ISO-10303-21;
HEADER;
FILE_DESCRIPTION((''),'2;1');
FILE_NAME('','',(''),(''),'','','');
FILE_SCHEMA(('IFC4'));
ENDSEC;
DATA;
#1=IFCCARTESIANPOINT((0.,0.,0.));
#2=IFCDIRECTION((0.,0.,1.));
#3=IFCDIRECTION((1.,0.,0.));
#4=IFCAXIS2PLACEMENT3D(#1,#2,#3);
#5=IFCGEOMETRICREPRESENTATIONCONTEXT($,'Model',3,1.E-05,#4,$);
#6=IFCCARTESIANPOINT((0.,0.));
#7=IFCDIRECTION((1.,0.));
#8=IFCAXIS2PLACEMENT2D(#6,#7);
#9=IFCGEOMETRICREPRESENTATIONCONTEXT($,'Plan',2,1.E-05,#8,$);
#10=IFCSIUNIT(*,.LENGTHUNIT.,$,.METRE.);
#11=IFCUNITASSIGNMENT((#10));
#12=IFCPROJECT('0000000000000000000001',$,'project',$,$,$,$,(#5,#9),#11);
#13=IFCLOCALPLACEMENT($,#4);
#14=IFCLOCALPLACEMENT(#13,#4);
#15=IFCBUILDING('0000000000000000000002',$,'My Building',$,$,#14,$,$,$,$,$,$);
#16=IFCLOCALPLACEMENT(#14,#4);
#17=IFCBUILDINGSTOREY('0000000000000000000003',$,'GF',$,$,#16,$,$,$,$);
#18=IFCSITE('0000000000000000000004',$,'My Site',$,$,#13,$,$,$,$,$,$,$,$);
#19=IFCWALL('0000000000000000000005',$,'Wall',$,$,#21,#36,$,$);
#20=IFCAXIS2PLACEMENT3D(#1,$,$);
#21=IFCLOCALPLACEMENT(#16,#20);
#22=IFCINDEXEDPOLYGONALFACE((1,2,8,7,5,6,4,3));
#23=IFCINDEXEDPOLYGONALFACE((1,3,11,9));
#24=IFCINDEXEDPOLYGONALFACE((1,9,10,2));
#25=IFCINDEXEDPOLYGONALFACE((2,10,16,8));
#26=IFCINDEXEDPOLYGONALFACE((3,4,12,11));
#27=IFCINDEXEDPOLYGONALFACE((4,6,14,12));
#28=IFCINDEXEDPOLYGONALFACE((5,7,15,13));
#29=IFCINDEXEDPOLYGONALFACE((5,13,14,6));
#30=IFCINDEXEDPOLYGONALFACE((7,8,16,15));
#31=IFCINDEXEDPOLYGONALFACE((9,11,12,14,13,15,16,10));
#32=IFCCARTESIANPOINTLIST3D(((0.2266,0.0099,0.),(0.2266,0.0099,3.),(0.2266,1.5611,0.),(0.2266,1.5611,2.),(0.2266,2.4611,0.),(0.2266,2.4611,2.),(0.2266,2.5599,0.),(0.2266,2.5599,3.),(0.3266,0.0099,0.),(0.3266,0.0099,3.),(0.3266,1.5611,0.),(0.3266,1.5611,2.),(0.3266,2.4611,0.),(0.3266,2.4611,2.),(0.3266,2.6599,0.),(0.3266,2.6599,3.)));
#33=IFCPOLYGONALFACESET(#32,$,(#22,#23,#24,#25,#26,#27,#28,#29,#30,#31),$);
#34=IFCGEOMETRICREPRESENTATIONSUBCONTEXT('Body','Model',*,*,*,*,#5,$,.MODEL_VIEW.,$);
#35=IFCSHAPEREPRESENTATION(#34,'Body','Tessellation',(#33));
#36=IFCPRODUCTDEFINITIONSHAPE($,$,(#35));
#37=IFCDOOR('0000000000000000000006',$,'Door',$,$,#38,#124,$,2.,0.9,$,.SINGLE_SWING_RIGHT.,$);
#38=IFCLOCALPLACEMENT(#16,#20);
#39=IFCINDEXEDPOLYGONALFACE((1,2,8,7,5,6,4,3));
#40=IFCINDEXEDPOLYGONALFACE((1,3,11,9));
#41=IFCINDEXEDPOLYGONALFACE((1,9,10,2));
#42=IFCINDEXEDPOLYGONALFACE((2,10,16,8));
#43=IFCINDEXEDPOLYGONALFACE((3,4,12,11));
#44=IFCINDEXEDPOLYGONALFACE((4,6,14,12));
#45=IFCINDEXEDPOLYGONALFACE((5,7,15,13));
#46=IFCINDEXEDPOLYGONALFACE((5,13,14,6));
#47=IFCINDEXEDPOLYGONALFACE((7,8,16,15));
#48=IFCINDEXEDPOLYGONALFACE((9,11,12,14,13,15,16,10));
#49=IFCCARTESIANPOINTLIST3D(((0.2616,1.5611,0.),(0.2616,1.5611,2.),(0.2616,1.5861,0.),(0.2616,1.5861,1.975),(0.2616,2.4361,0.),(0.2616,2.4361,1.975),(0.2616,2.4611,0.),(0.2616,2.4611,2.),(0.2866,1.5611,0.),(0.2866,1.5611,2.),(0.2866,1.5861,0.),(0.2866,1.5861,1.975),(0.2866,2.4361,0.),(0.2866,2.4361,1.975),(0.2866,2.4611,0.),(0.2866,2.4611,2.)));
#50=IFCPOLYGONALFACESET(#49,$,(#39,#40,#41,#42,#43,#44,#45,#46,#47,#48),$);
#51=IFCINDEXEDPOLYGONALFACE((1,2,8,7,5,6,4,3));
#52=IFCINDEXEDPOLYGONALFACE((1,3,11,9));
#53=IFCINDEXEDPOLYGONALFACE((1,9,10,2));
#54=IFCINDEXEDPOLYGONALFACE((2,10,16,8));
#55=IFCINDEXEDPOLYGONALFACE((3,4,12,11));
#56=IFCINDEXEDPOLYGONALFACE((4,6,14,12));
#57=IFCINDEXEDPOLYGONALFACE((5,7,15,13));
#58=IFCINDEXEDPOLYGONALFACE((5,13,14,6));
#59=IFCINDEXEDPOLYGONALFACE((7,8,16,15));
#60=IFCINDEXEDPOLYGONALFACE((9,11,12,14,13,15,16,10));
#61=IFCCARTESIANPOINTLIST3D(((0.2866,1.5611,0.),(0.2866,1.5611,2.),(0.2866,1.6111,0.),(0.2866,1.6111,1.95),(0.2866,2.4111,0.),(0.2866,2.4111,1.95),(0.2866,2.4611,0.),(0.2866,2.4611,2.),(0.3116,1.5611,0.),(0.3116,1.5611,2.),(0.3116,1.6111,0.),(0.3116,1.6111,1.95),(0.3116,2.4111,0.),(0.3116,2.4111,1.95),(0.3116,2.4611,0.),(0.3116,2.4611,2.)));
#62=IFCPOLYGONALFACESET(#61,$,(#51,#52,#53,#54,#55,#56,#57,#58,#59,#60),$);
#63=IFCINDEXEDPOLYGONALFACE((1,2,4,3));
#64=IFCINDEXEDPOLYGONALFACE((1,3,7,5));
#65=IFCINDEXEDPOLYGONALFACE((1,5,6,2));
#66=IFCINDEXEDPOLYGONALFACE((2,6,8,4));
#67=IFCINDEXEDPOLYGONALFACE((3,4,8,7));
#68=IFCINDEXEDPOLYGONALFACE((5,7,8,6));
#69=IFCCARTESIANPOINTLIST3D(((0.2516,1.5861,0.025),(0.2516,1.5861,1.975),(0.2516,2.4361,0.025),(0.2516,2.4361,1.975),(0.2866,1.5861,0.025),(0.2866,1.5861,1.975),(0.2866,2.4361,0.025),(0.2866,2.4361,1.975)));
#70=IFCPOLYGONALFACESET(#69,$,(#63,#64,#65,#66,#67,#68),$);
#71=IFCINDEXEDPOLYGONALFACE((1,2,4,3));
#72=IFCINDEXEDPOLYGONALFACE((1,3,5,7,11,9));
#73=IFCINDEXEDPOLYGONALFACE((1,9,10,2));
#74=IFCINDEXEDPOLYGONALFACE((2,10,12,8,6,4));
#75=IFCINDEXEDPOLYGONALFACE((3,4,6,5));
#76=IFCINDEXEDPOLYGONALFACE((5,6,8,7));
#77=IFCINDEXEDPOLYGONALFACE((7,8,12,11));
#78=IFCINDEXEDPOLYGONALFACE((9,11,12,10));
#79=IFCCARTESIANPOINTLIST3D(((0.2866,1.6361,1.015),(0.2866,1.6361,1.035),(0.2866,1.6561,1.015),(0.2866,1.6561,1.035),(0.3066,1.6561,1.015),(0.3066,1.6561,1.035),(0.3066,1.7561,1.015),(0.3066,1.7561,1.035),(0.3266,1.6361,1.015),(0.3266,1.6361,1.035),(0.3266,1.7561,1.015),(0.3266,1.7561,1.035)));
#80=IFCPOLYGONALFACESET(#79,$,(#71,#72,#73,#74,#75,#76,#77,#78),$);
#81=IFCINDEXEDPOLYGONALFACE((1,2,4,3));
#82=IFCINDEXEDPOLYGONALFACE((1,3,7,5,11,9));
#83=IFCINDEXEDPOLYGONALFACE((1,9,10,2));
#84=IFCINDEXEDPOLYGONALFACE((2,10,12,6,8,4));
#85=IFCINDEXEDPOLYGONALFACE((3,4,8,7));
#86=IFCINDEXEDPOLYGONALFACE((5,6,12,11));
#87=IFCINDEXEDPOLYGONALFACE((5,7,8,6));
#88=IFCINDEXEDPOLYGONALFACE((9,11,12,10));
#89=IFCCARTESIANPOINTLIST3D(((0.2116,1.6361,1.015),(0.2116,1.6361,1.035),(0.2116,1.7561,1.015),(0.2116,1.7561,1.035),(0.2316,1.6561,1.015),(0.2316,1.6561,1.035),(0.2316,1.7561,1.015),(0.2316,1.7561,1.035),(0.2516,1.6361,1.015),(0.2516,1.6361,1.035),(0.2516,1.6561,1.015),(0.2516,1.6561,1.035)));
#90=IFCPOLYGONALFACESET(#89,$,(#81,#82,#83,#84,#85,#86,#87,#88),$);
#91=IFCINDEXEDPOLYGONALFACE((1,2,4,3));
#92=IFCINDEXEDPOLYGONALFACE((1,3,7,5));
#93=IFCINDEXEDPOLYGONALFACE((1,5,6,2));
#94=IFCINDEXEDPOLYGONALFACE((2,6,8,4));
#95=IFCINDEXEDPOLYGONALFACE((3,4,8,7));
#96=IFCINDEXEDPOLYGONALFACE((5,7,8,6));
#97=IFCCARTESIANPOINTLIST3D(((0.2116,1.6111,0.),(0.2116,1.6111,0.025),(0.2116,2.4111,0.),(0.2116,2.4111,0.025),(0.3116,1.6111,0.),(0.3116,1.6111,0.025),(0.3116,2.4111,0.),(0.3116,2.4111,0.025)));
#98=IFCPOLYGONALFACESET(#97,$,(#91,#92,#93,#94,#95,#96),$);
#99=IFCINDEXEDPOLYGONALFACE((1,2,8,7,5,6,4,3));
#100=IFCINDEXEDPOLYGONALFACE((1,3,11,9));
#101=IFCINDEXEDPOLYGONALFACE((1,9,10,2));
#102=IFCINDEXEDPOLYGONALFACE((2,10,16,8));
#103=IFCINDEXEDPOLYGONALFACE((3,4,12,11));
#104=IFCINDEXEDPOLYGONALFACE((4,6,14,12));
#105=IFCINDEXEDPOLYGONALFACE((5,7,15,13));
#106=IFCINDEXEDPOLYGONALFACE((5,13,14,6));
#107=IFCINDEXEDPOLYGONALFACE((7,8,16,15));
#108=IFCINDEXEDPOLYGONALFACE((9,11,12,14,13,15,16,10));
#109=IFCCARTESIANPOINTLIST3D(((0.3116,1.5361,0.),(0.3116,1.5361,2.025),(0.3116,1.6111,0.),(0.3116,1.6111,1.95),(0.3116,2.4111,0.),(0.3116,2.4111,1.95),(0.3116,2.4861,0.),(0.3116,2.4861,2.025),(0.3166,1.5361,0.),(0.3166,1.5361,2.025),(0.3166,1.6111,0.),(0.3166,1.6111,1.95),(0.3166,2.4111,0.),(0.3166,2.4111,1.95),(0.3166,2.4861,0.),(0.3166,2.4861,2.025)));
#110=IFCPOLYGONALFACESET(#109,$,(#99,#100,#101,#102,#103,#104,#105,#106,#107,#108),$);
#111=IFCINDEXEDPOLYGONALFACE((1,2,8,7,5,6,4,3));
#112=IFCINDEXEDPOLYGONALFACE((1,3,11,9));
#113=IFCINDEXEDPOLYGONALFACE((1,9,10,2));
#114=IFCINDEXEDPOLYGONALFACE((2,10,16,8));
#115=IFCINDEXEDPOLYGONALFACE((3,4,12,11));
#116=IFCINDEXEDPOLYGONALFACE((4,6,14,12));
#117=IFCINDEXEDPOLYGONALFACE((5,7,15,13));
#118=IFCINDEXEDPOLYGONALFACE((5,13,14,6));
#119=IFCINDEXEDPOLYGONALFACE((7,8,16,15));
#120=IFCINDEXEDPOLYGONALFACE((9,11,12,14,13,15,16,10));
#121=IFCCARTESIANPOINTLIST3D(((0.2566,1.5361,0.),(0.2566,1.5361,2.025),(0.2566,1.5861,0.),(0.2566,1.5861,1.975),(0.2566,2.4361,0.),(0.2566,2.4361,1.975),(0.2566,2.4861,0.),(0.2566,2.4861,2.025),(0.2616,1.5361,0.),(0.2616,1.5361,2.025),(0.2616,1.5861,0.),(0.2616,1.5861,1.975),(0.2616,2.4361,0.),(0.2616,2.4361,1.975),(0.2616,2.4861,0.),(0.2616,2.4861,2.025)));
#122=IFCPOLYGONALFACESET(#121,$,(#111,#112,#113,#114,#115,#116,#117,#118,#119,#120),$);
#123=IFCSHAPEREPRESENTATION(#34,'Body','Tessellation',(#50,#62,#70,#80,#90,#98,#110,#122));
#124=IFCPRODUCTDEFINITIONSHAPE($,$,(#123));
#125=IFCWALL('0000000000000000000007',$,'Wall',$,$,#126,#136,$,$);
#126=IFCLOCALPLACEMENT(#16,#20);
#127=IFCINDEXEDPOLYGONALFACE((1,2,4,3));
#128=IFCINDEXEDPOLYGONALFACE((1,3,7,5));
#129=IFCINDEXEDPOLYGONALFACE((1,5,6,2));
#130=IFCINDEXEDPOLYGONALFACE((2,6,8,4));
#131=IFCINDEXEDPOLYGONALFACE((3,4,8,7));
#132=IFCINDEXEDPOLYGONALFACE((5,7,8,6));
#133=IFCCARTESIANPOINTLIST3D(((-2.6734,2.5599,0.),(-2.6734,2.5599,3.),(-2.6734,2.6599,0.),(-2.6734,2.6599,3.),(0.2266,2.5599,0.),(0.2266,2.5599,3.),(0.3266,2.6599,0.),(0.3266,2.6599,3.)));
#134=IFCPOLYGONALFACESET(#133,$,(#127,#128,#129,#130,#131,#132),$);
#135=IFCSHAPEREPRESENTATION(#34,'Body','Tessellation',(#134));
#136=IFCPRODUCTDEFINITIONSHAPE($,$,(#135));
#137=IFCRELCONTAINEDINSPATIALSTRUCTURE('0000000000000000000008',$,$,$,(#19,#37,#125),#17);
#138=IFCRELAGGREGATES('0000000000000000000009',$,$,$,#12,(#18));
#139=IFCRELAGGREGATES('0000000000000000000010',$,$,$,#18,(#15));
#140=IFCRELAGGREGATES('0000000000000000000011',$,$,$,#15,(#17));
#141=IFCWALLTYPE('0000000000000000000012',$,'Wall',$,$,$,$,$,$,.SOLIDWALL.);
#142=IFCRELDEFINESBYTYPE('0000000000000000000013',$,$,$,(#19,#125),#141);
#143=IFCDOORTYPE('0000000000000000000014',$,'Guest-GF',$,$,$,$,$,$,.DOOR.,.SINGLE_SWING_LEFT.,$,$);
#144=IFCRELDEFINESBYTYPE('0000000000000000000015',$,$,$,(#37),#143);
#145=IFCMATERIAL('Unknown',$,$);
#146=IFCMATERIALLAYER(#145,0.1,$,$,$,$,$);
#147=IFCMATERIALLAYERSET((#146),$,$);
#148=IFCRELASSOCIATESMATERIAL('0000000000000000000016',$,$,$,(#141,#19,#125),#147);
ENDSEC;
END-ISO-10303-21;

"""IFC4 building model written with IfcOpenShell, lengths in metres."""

from ifc_helpers import new_model, entity, si_unit, frame, origin_with_axes, origin_2d_with_axis, place, context, subcontext, project, spatial, line, indexed_curve, outline, extrude, shape, source, transform, mapped, material, layer, layer_set, layer_usage, type_object, type_shapes, element, fill, save


model = new_model("IFC4")

# Units and contexts
model_context = context("Model", 3, precision=1e-05, world=origin_with_axes())
plan_context = context("Plan", 2, precision=1e-05, world=origin_2d_with_axis())
body_context_1 = subcontext(model_context, "Body", "Model", "MODEL_VIEW")
body_context_2 = subcontext(plan_context, "Body", "Plan", "PLAN_VIEW")
ifc_project = project(units=[si_unit("LENGTHUNIT", "METRE")], contexts=[model_context, plan_context])

# Site, building, storey
site_placement = place(None, origin_with_axes())
site = spatial("IfcSite", under=ifc_project, at=site_placement, Name="My Site")
building_placement = place(site_placement, origin_with_axes())
building = spatial("IfcBuilding", under=site, at=building_placement, Name="My Building")
storey_placement = place(building_placement, origin_with_axes())
storey = spatial("IfcBuildingStorey", under=building, at=storey_placement, Name="GF")

# Shared definitions
ifc_material = material(Name="Unknown")

# Shared definitions
ifc_layer_1 = layer(ifc_material, 0.1)
ifc_layer_set_1 = layer_set([ifc_layer_1])
wall_type = type_object("IfcWallType", Name="Wall", PredefinedType="SOLIDWALL", material=ifc_layer_set_1)

# Wall, opening, door
ifc_layer_usage_1 = layer_usage(ifc_layer_set_1, "AXIS2", "POSITIVE", 0.0)
wall_1_placement = place(storey_placement, frame((0.3266, 0.0099, 0.0), z_axis=(0.0, 0.0, 1.0), x_axis=(0.0, 1.0, 0.0)))
wall_1 = element("IfcWall", 1, at=wall_1_placement, inside=storey, type_object=wall_type, material=ifc_layer_usage_1, Name="Wall", context=body_context_1, shape_type="SweptSolid", body=[
    extrude(outline(indexed_curve([(0.0, 0.0), (0.0, 0.1), (2.55, 0.1), (2.65, 0.0)], segments=[line(1, 2, 3, 4, 1)])), origin_with_axes(), (0.0, 0.0, 1.0), 3.0),
])
shared_shape_1 = source(origin_with_axes(), body_context_1, "Body", "SweptSolid", [
    extrude(outline(indexed_curve([(0.0, 0.0), (0.9, 0.0), (0.9, 2.0), (0.0, 2.0)], segments=[line(1, 2, 3, 4, 1)])), frame((0.0, -0.6, 0.0), z_axis=(0.0, -1.0, 0.0), x_axis=(1.0, 0.0, 0.0)), (0.0, 0.0, -1.0), 1.2),
])
opening_1_placement = place(wall_1_placement, frame((1.5512, 0.015, 0.0), z_axis=(0.0, 0.0, 1.0), x_axis=(1.0, 0.0, 0.0)))
opening_1 = element("IfcOpeningElement", 2, at=opening_1_placement, cuts=wall_1, PredefinedType="OPENING", context=body_context_1, shape_type="MappedRepresentation", body=[
    mapped(shared_shape_1, transform((0.0, 0.0, 0.0), x_axis=(1.0, 0.0, 0.0), y_axis=(0.0, 1.0, 0.0), z_axis=(0.0, 0.0, 1.0), scale=1.0)),
])
door_type_1 = type_object("IfcDoorType", Name="Guest-GF", OperationType="SINGLE_SWING_LEFT", PredefinedType="DOOR")
shared_shape_2 = source(origin_with_axes(), body_context_1, "Body", "SweptSolid", [
    extrude(outline(indexed_curve([(0.0, 0.0), (0.0, 2.0), (0.9, 2.0), (0.9, 0.0), (0.875, 0.0), (0.875, 1.975), (0.025, 1.975), (0.025, 0.0)], segments=[line(1, 2, 3, 4, 5, 6, 7, 8, 1)])), frame((0.0, 0.025, 0.0), z_axis=(0.0, -1.0, 0.0), x_axis=(1.0, 0.0, 0.0)), (0.0, 0.0, -1.0), 0.025),
    extrude(outline(indexed_curve([(0.0, 0.0), (0.0, 2.0), (0.9, 2.0), (0.9, 0.0), (0.85, 0.0), (0.85, 1.95), (0.05, 1.95), (0.05, 0.0)], segments=[line(1, 2, 3, 4, 5, 6, 7, 8, 1)])), frame((0.0, 0.0, 0.0), z_axis=(0.0, -1.0, 0.0), x_axis=(1.0, 0.0, 0.0)), (0.0, 0.0, -1.0), 0.025),
    extrude(outline(indexed_curve([(0.0, 0.0), (0.85, 0.0), (0.85, 0.035), (0.0, 0.035)], segments=[line(1, 2, 3, 4, 1)])), frame((0.025, 0.025, 0.025), z_axis=(0.0, 0.0, 1.0), x_axis=(1.0, 0.0, 0.0)), (0.0, 0.0, 1.0), 1.95),
    extrude(outline(indexed_curve([(0.0, 0.0), (0.0, -0.04), (0.12, -0.04), (0.12, -0.02), (0.02, -0.02), (0.02, 0.0)], segments=[line(1, 2, 3, 4, 5, 6, 1)])), frame((0.075, 0.025, 1.015), z_axis=(0.0, 0.0, 1.0), x_axis=(1.0, 0.0, 0.0)), (0.0, 0.0, 1.0), 0.02),
    extrude(outline(indexed_curve([(0.0, 0.0), (0.0, 0.04), (0.12, 0.04), (0.12, 0.02), (0.02, 0.02), (0.02, 0.0)], segments=[line(1, 2, 3, 4, 5, 6, 1)])), frame((0.075, 0.06, 1.015), z_axis=(0.0, 0.0, 1.0), x_axis=(1.0, 0.0, 0.0)), (0.0, 0.0, 1.0), 0.02),
    extrude(outline(indexed_curve([(0.0, 0.0), (0.8, 0.0), (0.8, 0.1), (0.0, 0.1)], segments=[line(1, 2, 3, 4, 1)])), frame((0.05, 0.0, 0.0), z_axis=(0.0, 0.0, 1.0), x_axis=(1.0, 0.0, 0.0)), (0.0, 0.0, 1.0), 0.025),
    extrude(outline(indexed_curve([(0.0, 0.0), (0.0, 2.025), (0.95, 2.025), (0.95, 0.0), (0.875, 0.0), (0.875, 1.95), (0.075, 1.95), (0.075, 0.0)], segments=[line(1, 2, 3, 4, 5, 6, 7, 8, 1)])), frame((-0.025, -0.005, 0.0), z_axis=(0.0, -1.0, 0.0), x_axis=(1.0, 0.0, 0.0)), (0.0, 0.0, -1.0), 0.005),
    extrude(outline(indexed_curve([(0.0, 0.0), (0.0, 2.025), (0.95, 2.025), (0.95, 0.0), (0.9, 0.0), (0.9, 1.975), (0.05, 1.975), (0.05, 0.0)], segments=[line(1, 2, 3, 4, 5, 6, 7, 8, 1)])), frame((-0.025, 0.05, 0.0), z_axis=(0.0, -1.0, 0.0), x_axis=(1.0, 0.0, 0.0)), (0.0, 0.0, -1.0), 0.005),
])
shared_shape_3 = source(origin_with_axes(), body_context_2, "Body", "Curve2D", [
    entity("IfcIndexedPolyCurve", entity("IfcCartesianPointList2D", [[0.0, 0.0], [0.0, 0.05], [0.025, 0.05], [0.025, 0.025], [0.05, 0.025], [0.05, 0.0]]), [entity("IfcLineIndex", [1, 2, 3, 4, 5, 6, 1])]),
    entity("IfcIndexedPolyCurve", entity("IfcCartesianPointList2D", [[0.9, 0.0], [0.9, 0.05], [0.875, 0.05], [0.875, 0.025], [0.85, 0.025], [0.85, 0.0]]), [entity("IfcLineIndex", [1, 2, 3, 4, 5, 6, 1])]),
    entity("IfcTrimmedCurve", entity("IfcEllipse", entity("IfcAxis2Placement2D", entity("IfcCartesianPoint", [0.84, 0.05]), entity("IfcDirection", [1.0, 0.0])), 0.815, 0.85), [entity("IfcCartesianPoint", [0.84, 0.9])], [entity("IfcCartesianPoint", [0.025, 0.05])], True, "CARTESIAN"),
    entity("IfcIndexedPolyCurve", entity("IfcCartesianPointList2D", [[0.875, 0.05], [0.84, 0.05], [0.84, 0.9], [0.875, 0.9]]), [entity("IfcLineIndex", [1, 2, 3, 4, 1])]),
])
type_shapes(door_type_1, [shared_shape_2, shared_shape_3])
door_1_placement = place(opening_1_placement, frame((0.0, 0.0, 0.0), z_axis=(0.0, 0.0, 1.0), x_axis=(1.0, 0.0, 0.0)))
door_1 = element("IfcDoor", 3, at=door_1_placement, inside=storey, type_object=door_type_1, Name="Door", OperationType="SINGLE_SWING_RIGHT", OverallHeight=2.0, OverallWidth=0.9, shapes=[
    shape(body_context_1, "Body", "MappedRepresentation", [mapped(shared_shape_2, transform((0.0, 0.0, 0.0), x_axis=(1.0, 0.0, 0.0), y_axis=(0.0, 1.0, 0.0), z_axis=(0.0, 0.0, 1.0), scale=1.0))]),
    shape(body_context_2, "Body", "MappedRepresentation", [mapped(shared_shape_3, transform((0.0, 0.0, 0.0), x_axis=(1.0, 0.0, 0.0), y_axis=(0.0, 1.0, 0.0), z_axis=(0.0, 0.0, 1.0), scale=1.0))]),
])
fill(opening_1, door_1)

# Wall
ifc_layer_usage_2 = layer_usage(ifc_layer_set_1, "AXIS2", "POSITIVE", 0.0)
wall_2_placement = place(storey_placement, frame((0.3266, 2.6599, 0.0), z_axis=(0.0, 0.0, 1.0), x_axis=(-1.0, 0.0, 0.0)))
element("IfcWall", 4, at=wall_2_placement, inside=storey, type_object=wall_type, material=ifc_layer_usage_2, Name="Wall", context=body_context_1, shape_type="SweptSolid", body=[
    extrude(outline(indexed_curve([(0.0, 0.0), (0.1, 0.1), (3.0, 0.1), (3.0, 0.0)], segments=[line(1, 2, 3, 4, 1)])), origin_with_axes(), (0.0, 0.0, 1.0), 3.0),
])

save(model, "model.ifc")
